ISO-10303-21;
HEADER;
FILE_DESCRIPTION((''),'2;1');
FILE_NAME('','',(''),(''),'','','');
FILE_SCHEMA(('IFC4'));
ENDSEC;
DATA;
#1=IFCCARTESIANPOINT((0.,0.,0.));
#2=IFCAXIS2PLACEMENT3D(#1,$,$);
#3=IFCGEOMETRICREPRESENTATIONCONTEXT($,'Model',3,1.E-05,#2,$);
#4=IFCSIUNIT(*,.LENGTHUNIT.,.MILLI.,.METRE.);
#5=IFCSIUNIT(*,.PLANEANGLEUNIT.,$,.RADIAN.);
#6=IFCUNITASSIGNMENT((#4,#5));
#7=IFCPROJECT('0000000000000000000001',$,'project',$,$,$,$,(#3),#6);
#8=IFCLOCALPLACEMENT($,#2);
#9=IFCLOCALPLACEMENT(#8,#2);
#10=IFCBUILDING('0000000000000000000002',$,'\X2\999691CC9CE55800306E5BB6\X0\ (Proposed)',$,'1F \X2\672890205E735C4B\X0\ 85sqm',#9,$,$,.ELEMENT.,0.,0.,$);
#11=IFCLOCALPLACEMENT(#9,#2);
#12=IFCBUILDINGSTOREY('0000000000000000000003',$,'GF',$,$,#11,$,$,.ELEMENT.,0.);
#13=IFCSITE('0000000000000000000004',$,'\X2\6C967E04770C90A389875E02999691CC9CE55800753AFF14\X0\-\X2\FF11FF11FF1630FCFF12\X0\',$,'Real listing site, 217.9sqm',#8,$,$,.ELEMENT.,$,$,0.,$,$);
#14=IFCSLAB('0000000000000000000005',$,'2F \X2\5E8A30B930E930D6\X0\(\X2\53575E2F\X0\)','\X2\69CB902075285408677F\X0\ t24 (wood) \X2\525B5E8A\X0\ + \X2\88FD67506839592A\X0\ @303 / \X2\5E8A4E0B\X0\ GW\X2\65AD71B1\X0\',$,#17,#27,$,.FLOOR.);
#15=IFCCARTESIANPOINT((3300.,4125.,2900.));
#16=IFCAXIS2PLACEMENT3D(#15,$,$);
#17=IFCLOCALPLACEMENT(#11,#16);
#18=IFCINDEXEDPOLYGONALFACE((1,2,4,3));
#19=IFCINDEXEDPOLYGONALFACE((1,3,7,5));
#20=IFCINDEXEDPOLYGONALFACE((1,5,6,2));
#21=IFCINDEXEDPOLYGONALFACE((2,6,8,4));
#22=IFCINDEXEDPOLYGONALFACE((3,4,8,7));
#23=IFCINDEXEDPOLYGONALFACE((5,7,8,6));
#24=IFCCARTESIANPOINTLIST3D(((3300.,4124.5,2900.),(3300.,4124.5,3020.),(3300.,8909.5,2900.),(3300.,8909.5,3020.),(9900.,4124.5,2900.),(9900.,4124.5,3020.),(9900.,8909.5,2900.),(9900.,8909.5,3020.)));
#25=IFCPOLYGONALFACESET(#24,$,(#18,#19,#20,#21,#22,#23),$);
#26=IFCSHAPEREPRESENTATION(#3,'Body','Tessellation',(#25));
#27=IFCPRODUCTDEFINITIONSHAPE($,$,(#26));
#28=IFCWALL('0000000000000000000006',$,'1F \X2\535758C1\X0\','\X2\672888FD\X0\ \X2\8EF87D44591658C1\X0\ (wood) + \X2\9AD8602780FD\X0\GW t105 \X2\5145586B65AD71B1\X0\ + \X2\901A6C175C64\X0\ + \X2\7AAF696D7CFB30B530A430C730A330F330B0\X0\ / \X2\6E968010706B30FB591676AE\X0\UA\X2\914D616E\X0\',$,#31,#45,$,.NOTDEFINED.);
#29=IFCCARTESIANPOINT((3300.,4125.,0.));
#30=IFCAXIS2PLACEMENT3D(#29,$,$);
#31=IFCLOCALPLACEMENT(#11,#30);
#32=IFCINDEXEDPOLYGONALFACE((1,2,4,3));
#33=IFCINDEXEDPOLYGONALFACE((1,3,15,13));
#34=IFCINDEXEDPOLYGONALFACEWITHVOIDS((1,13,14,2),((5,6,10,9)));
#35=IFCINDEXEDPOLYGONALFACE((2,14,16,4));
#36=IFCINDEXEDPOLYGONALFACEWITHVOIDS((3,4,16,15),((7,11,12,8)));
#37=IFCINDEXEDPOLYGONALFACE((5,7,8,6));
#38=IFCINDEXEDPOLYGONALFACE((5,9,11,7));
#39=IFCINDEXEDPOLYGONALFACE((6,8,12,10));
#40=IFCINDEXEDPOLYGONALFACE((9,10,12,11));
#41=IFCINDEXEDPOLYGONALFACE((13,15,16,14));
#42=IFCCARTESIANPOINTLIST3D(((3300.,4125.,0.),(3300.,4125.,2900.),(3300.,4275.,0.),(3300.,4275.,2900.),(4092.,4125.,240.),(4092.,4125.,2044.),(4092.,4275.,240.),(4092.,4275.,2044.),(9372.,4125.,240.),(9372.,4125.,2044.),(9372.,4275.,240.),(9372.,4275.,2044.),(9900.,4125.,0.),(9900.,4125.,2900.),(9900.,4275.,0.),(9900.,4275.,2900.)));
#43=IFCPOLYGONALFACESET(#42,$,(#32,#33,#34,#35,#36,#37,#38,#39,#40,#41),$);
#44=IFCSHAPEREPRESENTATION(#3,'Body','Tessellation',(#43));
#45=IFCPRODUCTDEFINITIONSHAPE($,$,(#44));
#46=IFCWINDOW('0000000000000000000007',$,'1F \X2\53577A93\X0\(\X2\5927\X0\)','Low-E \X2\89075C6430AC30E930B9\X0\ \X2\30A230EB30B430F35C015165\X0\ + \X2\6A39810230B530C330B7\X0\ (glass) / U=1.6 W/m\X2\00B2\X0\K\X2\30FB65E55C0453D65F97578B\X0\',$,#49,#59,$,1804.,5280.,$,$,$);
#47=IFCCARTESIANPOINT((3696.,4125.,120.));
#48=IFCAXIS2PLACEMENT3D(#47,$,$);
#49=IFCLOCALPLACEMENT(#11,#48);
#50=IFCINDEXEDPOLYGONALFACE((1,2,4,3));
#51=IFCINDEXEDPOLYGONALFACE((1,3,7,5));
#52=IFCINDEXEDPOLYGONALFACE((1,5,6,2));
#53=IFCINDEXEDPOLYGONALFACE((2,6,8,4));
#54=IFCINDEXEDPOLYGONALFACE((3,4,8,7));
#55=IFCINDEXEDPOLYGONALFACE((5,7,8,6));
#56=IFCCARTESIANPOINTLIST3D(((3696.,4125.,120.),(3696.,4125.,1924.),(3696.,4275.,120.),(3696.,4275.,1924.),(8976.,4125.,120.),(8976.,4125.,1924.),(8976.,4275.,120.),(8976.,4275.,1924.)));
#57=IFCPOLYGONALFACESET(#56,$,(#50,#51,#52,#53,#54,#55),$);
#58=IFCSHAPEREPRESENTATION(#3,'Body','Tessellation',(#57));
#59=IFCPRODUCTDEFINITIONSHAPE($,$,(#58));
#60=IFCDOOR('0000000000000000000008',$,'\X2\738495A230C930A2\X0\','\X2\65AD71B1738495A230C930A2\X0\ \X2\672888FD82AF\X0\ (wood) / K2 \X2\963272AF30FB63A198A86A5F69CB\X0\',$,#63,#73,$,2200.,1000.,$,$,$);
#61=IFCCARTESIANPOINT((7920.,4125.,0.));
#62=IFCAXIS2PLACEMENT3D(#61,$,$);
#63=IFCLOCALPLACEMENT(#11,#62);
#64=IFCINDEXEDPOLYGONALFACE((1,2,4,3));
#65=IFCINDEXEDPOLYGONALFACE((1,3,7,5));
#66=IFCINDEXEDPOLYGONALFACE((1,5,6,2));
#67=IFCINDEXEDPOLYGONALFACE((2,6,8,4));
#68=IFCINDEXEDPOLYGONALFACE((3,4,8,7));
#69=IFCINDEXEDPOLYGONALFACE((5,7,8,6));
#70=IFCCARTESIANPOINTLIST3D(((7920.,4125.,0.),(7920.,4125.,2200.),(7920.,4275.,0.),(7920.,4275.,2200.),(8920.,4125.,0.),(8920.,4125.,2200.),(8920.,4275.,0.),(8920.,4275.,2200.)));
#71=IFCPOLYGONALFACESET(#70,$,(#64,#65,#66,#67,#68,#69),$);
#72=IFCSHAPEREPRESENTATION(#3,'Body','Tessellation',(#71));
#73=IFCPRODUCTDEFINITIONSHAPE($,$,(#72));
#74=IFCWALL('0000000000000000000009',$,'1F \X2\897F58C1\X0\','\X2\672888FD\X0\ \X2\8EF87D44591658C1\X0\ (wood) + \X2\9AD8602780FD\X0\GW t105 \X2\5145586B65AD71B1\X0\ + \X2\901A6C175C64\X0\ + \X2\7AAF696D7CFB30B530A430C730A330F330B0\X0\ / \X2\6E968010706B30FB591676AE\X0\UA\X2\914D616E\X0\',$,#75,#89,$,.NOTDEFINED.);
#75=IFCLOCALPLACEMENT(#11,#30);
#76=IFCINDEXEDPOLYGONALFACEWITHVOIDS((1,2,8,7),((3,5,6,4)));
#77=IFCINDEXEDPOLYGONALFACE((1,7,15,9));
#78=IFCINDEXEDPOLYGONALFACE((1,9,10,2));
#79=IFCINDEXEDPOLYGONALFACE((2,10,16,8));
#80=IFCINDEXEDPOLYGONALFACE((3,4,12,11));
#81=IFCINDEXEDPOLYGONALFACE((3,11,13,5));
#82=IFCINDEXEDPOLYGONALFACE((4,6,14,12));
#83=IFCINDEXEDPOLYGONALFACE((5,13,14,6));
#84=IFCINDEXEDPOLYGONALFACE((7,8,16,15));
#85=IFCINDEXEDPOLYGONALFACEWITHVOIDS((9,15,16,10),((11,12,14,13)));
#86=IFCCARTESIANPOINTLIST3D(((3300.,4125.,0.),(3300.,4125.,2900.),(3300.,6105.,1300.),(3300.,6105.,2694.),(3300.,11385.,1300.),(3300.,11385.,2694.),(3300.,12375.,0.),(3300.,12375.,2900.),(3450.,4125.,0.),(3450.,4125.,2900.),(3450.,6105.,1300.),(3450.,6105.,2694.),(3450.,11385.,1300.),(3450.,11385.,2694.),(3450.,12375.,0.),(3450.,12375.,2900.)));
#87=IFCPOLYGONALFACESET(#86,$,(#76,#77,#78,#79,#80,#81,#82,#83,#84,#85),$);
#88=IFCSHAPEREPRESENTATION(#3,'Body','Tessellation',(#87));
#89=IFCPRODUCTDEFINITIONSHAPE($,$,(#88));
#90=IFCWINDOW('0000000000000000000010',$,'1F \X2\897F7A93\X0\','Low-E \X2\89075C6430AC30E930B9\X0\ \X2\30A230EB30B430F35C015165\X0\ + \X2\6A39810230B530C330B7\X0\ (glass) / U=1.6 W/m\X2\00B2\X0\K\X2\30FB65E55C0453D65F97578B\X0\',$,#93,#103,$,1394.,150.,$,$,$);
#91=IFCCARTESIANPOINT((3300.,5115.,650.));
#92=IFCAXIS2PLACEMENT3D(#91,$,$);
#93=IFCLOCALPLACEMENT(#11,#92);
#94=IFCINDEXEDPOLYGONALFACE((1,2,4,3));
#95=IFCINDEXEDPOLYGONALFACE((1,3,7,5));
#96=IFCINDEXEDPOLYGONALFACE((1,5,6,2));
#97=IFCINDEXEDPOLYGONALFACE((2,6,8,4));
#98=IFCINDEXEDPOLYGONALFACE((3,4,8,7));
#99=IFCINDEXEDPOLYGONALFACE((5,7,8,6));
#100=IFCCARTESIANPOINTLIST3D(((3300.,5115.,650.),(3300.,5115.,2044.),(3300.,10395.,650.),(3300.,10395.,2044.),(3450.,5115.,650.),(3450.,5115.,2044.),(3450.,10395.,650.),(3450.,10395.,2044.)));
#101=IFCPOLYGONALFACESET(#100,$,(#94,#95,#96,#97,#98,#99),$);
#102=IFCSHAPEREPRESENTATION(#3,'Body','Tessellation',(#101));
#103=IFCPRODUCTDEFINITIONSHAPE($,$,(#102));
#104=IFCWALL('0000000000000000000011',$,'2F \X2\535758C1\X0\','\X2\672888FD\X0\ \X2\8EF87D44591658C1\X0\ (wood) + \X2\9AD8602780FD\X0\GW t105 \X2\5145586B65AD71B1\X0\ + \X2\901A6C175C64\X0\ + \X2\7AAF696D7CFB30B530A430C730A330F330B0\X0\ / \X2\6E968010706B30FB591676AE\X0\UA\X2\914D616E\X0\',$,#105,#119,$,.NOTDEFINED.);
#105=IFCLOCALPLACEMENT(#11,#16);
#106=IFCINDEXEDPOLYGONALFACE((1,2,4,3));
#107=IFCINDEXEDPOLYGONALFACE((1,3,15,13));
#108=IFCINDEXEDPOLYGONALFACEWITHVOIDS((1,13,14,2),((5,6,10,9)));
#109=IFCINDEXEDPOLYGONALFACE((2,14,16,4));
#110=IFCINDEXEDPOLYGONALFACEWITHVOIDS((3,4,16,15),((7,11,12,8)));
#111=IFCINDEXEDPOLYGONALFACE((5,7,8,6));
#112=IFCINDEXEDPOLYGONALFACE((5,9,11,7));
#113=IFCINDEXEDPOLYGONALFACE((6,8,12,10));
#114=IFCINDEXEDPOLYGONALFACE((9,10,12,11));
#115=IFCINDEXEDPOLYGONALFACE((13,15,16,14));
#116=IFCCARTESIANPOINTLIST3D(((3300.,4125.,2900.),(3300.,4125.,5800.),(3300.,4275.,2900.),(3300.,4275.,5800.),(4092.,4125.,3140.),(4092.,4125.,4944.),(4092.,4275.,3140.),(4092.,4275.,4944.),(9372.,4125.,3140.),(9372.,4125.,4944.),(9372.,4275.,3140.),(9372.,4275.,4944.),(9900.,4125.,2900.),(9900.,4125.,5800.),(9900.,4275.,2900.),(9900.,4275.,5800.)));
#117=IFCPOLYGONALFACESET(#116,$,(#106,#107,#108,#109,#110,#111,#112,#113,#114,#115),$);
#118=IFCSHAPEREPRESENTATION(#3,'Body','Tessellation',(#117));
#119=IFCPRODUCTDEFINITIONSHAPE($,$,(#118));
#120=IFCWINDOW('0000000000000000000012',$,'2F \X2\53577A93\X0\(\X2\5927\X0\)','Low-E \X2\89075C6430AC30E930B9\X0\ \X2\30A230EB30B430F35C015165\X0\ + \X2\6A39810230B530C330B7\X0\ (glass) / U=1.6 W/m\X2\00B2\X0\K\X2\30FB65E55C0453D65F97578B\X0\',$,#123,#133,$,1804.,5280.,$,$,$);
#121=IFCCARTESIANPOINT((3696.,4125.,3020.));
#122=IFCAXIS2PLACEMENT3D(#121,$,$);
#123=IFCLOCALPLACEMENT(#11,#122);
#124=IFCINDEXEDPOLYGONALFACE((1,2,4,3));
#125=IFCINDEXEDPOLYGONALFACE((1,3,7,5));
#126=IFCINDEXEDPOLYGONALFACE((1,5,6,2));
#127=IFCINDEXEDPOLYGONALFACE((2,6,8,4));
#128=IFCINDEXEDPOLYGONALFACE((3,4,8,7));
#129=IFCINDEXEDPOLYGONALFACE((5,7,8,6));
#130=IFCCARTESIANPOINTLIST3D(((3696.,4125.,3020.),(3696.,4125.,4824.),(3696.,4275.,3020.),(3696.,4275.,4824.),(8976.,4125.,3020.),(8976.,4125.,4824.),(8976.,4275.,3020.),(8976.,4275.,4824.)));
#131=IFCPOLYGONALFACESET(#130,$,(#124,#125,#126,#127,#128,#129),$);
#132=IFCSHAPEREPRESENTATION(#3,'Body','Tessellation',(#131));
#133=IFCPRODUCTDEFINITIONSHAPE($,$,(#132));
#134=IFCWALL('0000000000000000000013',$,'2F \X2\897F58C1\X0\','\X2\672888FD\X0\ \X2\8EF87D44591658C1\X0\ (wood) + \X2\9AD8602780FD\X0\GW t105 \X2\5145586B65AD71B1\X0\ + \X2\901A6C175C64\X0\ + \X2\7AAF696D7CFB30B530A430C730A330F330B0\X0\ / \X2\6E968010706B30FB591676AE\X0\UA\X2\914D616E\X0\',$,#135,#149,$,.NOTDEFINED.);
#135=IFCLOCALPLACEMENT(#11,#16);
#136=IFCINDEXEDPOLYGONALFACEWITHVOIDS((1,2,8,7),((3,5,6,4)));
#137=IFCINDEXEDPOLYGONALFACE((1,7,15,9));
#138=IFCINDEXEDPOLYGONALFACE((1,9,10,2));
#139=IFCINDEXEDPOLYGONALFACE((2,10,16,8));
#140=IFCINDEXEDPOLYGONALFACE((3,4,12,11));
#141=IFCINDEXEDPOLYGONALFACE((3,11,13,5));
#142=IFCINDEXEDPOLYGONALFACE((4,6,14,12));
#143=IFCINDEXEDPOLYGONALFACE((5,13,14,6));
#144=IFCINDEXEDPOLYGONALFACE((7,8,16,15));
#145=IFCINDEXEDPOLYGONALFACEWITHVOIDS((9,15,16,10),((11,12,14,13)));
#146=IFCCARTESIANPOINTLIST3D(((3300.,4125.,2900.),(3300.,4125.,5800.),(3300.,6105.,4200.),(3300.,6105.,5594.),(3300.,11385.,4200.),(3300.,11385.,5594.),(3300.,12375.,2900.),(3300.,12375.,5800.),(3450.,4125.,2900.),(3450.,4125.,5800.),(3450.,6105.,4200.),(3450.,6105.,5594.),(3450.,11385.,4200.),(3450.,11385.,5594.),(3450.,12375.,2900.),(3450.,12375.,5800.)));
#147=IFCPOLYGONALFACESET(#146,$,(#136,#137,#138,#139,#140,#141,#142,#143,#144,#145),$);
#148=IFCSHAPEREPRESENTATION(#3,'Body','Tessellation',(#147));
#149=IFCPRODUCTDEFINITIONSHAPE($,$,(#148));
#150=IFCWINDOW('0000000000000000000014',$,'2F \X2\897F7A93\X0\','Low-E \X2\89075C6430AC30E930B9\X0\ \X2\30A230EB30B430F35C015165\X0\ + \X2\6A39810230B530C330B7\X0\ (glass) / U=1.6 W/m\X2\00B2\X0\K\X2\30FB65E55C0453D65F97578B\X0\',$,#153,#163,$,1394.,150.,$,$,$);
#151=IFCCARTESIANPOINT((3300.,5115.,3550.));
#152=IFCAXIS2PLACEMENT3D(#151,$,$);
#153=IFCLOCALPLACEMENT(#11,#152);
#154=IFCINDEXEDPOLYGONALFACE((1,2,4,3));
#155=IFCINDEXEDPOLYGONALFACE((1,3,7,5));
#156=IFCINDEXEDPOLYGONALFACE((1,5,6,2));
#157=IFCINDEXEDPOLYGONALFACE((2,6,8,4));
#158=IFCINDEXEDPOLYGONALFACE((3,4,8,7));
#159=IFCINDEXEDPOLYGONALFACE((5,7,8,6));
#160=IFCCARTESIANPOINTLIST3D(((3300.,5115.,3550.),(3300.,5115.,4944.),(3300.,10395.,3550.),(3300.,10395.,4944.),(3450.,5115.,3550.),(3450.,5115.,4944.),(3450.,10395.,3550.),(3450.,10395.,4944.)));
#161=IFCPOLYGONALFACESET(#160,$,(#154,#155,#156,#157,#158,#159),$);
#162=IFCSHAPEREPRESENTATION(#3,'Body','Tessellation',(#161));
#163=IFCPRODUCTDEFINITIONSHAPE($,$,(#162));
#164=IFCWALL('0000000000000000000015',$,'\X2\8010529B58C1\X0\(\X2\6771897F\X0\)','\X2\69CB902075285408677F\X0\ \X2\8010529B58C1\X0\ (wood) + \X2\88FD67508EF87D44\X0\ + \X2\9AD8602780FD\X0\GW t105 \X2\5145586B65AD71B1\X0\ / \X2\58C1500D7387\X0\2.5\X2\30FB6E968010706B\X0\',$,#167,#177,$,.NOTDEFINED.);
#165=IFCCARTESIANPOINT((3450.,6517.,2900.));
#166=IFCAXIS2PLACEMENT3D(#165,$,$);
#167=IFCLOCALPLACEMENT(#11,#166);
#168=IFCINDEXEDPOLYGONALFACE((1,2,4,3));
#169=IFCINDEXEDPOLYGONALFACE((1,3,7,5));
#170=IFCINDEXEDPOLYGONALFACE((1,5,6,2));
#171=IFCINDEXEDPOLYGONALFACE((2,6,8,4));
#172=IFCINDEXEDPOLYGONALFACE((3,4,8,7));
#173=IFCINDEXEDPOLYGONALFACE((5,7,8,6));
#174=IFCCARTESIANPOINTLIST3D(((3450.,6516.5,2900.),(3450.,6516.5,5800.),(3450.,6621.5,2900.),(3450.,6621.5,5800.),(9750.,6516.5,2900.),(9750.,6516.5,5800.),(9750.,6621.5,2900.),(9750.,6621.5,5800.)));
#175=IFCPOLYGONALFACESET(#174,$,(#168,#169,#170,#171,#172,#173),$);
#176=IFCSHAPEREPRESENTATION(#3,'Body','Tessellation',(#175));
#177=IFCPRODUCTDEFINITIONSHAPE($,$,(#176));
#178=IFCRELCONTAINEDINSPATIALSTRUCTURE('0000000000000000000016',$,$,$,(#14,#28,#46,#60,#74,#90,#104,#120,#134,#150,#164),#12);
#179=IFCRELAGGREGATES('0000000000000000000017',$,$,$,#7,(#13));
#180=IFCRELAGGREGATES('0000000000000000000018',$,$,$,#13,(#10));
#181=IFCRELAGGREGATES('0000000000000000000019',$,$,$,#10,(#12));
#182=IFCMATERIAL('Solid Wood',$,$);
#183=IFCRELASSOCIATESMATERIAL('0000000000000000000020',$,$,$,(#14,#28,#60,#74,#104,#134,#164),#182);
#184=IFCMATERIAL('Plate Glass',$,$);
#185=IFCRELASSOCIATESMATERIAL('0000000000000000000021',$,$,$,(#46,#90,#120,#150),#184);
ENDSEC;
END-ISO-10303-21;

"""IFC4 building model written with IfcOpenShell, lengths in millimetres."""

from ifc_helpers import new_model, si_unit, frame, frame_2d, origin, place, context, project, spatial, rectangle, extrude, material, element, fill, save


model = new_model("IFC4")

# Units and contexts
model_context = context("Model", 3, precision=1e-05, world=origin())
ifc_project = project(units=[si_unit("LENGTHUNIT", "METRE", prefix="MILLI"), si_unit("PLANEANGLEUNIT", "RADIAN")], contexts=[model_context])

# Site, building, storey
site_placement = place(None, origin())
site = spatial("IfcSite", under=ifc_project, at=site_placement, Name="沖縄県那覇市首里鳥堀町４-１１６ー２", ObjectType="Real listing site, 217.9sqm", CompositionType="ELEMENT", RefElevation=0.0)
building_placement = place(site_placement, origin())
building = spatial("IfcBuilding", under=site, at=building_placement, Name="首里鳥堀の家 (Proposed)", ObjectType="1F 木造平屋 85sqm", CompositionType="ELEMENT", ElevationOfRefHeight=0.0, ElevationOfTerrain=0.0)
storey_placement = place(building_placement, origin())
storey = spatial("IfcBuildingStorey", under=building, at=storey_placement, Name="GF", CompositionType="ELEMENT", Elevation=0.0)

# Slab
ifc_material_1 = material(Name="Solid Wood")
slab_1_placement = place(storey_placement, frame((3300.0, 4125.0, 2900.0)))
element("IfcSlab", 1, at=slab_1_placement, inside=storey, material=ifc_material_1, Name="2F 床スラブ(南帯)", Description="構造用合板 t24 (wood) 剛床 + 製材根太 @303 / 床下 GW断熱", PredefinedType="FLOOR", context=model_context, shape_type="SweptSolid", body=[
    extrude(rectangle(XDim=6600.0, YDim=4785.0, at=frame_2d((3300.0, 2392.0))), frame((3300.0, 4125.0, 2900.0)), (0.0, 0.0, 1.0), 120.0),
])

# Wall, openings, window, door
wall_1_placement = place(storey_placement, frame((3300.0, 4125.0, 0.0)))
wall_1 = element("IfcWall", 2, at=wall_1_placement, inside=storey, material=ifc_material_1, Name="1F 南壁", Description="木製 軸組外壁 (wood) + 高性能GW t105 充填断熱 + 通気層 + 窯業系サイディング / 準耐火・外皮UA配慮", PredefinedType="NOTDEFINED", context=model_context, shape_type="SweptSolid", body=[
    extrude(rectangle(XDim=6600.0, YDim=150.0, at=frame_2d((3300.0, 75.0))), frame((3300.0, 4125.0, 0.0)), (0.0, 0.0, 1.0), 2900.0),
])
opening_1_placement = place(storey_placement, frame((3696.0, 4125.0, 120.0)))
opening_1 = element("IfcOpeningElement", 3, at=opening_1_placement, cuts=wall_1, PredefinedType="NOTDEFINED", context=model_context, shape_type="SweptSolid", body=[
    extrude(rectangle(XDim=5280.0, YDim=150.0, at=frame_2d((2640.0, 75.0))), frame((3696.0, 4125.0, 120.0)), (0.0, 0.0, 1.0), 1804.0),
])
opening_2_placement = place(storey_placement, frame((7920.0, 4125.0, 0.0)))
opening_2 = element("IfcOpeningElement", 4, at=opening_2_placement, cuts=wall_1, PredefinedType="NOTDEFINED", context=model_context, shape_type="SweptSolid", body=[
    extrude(rectangle(XDim=1000.0, YDim=150.0, at=frame_2d((500.0, 75.0))), frame((7920.0, 4125.0, 0.0)), (0.0, 0.0, 1.0), 2200.0),
])
ifc_material_2 = material(Name="Plate Glass")
window_1_placement = place(storey_placement, frame((3696.0, 4125.0, 120.0)))
window_1 = element("IfcWindow", 5, at=window_1_placement, inside=storey, material=ifc_material_2, Name="1F 南窓(大)", Description="Low-E 複層ガラス アルゴン封入 + 樹脂サッシ (glass) / U=1.6 W/m²K・日射取得型", OverallHeight=1804.0, OverallWidth=5280.0, context=model_context, shape_type="SweptSolid", body=[
    extrude(rectangle(XDim=5280.0, YDim=150.0, at=frame_2d((2640.0, 75.0))), frame((3696.0, 4125.0, 120.0)), (0.0, 0.0, 1.0), 1804.0),
])
fill(opening_1, window_1)
door_placement = place(storey_placement, frame((7920.0, 4125.0, 0.0)))
door = element("IfcDoor", 6, at=door_placement, inside=storey, material=ifc_material_1, Name="玄関ドア", Description="断熱玄関ドア 木製芯 (wood) / K2 防犯・採風機構", OverallHeight=2200.0, OverallWidth=1000.0, context=model_context, shape_type="SweptSolid", body=[
    extrude(rectangle(XDim=1000.0, YDim=150.0, at=frame_2d((500.0, 75.0))), frame((7920.0, 4125.0, 0.0)), (0.0, 0.0, 1.0), 2200.0),
])
fill(opening_2, door)

# Wall, opening, window
wall_2_placement = place(storey_placement, frame((3300.0, 4125.0, 0.0)))
wall_2 = element("IfcWall", 7, at=wall_2_placement, inside=storey, material=ifc_material_1, Name="1F 西壁", Description="木製 軸組外壁 (wood) + 高性能GW t105 充填断熱 + 通気層 + 窯業系サイディング / 準耐火・外皮UA配慮", PredefinedType="NOTDEFINED", context=model_context, shape_type="SweptSolid", body=[
    extrude(rectangle(XDim=150.0, YDim=8250.0, at=frame_2d((75.0, 4125.0))), frame((3300.0, 4125.0, 0.0)), (0.0, 0.0, 1.0), 2900.0),
])
opening_3_placement = place(storey_placement, frame((3300.0, 5115.0, 650.0)))
opening_3 = element("IfcOpeningElement", 8, at=opening_3_placement, cuts=wall_2, PredefinedType="NOTDEFINED", context=model_context, shape_type="SweptSolid", body=[
    extrude(rectangle(XDim=150.0, YDim=5280.0, at=frame_2d((75.0, 2640.0))), frame((3300.0, 5115.0, 650.0)), (0.0, 0.0, 1.0), 1394.0),
])
window_2_placement = place(storey_placement, frame((3300.0, 5115.0, 650.0)))
window_2 = element("IfcWindow", 9, at=window_2_placement, inside=storey, material=ifc_material_2, Name="1F 西窓", Description="Low-E 複層ガラス アルゴン封入 + 樹脂サッシ (glass) / U=1.6 W/m²K・日射取得型", OverallHeight=1394.0, OverallWidth=150.0, context=model_context, shape_type="SweptSolid", body=[
    extrude(rectangle(XDim=150.0, YDim=5280.0, at=frame_2d((75.0, 2640.0))), frame((3300.0, 5115.0, 650.0)), (0.0, 0.0, 1.0), 1394.0),
])
fill(opening_3, window_2)

# Walls, openings, windows
wall_3_placement = place(storey_placement, frame((3300.0, 4125.0, 2900.0)))
wall_3 = element("IfcWall", 10, at=wall_3_placement, inside=storey, material=ifc_material_1, Name="2F 南壁", Description="木製 軸組外壁 (wood) + 高性能GW t105 充填断熱 + 通気層 + 窯業系サイディング / 準耐火・外皮UA配慮", PredefinedType="NOTDEFINED", context=model_context, shape_type="SweptSolid", body=[
    extrude(rectangle(XDim=6600.0, YDim=150.0, at=frame_2d((3300.0, 75.0))), frame((3300.0, 4125.0, 2900.0)), (0.0, 0.0, 1.0), 2900.0),
])
opening_4_placement = place(storey_placement, frame((3696.0, 4125.0, 3020.0)))
opening_4 = element("IfcOpeningElement", 11, at=opening_4_placement, cuts=wall_3, PredefinedType="NOTDEFINED", context=model_context, shape_type="SweptSolid", body=[
    extrude(rectangle(XDim=5280.0, YDim=150.0, at=frame_2d((2640.0, 75.0))), frame((3696.0, 4125.0, 3020.0)), (0.0, 0.0, 1.0), 1804.0),
])
window_3_placement = place(storey_placement, frame((3696.0, 4125.0, 3020.0)))
window_3 = element("IfcWindow", 12, at=window_3_placement, inside=storey, material=ifc_material_2, Name="2F 南窓(大)", Description="Low-E 複層ガラス アルゴン封入 + 樹脂サッシ (glass) / U=1.6 W/m²K・日射取得型", OverallHeight=1804.0, OverallWidth=5280.0, context=model_context, shape_type="SweptSolid", body=[
    extrude(rectangle(XDim=5280.0, YDim=150.0, at=frame_2d((2640.0, 75.0))), frame((3696.0, 4125.0, 3020.0)), (0.0, 0.0, 1.0), 1804.0),
])
fill(opening_4, window_3)
wall_4_placement = place(storey_placement, frame((3300.0, 4125.0, 2900.0)))
wall_4 = element("IfcWall", 13, at=wall_4_placement, inside=storey, material=ifc_material_1, Name="2F 西壁", Description="木製 軸組外壁 (wood) + 高性能GW t105 充填断熱 + 通気層 + 窯業系サイディング / 準耐火・外皮UA配慮", PredefinedType="NOTDEFINED", context=model_context, shape_type="SweptSolid", body=[
    extrude(rectangle(XDim=150.0, YDim=8250.0, at=frame_2d((75.0, 4125.0))), frame((3300.0, 4125.0, 2900.0)), (0.0, 0.0, 1.0), 2900.0),
])
opening_5_placement = place(storey_placement, frame((3300.0, 5115.0, 3550.0)))
opening_5 = element("IfcOpeningElement", 14, at=opening_5_placement, cuts=wall_4, PredefinedType="NOTDEFINED", context=model_context, shape_type="SweptSolid", body=[
    extrude(rectangle(XDim=150.0, YDim=5280.0, at=frame_2d((75.0, 2640.0))), frame((3300.0, 5115.0, 3550.0)), (0.0, 0.0, 1.0), 1394.0),
])
window_4_placement = place(storey_placement, frame((3300.0, 5115.0, 3550.0)))
window_4 = element("IfcWindow", 15, at=window_4_placement, inside=storey, material=ifc_material_2, Name="2F 西窓", Description="Low-E 複層ガラス アルゴン封入 + 樹脂サッシ (glass) / U=1.6 W/m²K・日射取得型", OverallHeight=1394.0, OverallWidth=150.0, context=model_context, shape_type="SweptSolid", body=[
    extrude(rectangle(XDim=150.0, YDim=5280.0, at=frame_2d((75.0, 2640.0))), frame((3300.0, 5115.0, 3550.0)), (0.0, 0.0, 1.0), 1394.0),
])
fill(opening_5, window_4)

# Wall
wall_5_placement = place(storey_placement, frame((3450.0, 6517.0, 2900.0)))
element("IfcWall", 16, at=wall_5_placement, inside=storey, material=ifc_material_1, Name="耐力壁(東西)", Description="構造用合板 耐力壁 (wood) + 製材軸組 + 高性能GW t105 充填断熱 / 壁倍率2.5・準耐火", PredefinedType="NOTDEFINED", context=model_context, shape_type="SweptSolid", body=[
    extrude(rectangle(XDim=6300.0, YDim=105.0, at=frame_2d((3150.0, 52.0))), frame((3450.0, 6517.0, 2900.0)), (0.0, 0.0, 1.0), 2900.0),
])

save(model, "model.ifc")
